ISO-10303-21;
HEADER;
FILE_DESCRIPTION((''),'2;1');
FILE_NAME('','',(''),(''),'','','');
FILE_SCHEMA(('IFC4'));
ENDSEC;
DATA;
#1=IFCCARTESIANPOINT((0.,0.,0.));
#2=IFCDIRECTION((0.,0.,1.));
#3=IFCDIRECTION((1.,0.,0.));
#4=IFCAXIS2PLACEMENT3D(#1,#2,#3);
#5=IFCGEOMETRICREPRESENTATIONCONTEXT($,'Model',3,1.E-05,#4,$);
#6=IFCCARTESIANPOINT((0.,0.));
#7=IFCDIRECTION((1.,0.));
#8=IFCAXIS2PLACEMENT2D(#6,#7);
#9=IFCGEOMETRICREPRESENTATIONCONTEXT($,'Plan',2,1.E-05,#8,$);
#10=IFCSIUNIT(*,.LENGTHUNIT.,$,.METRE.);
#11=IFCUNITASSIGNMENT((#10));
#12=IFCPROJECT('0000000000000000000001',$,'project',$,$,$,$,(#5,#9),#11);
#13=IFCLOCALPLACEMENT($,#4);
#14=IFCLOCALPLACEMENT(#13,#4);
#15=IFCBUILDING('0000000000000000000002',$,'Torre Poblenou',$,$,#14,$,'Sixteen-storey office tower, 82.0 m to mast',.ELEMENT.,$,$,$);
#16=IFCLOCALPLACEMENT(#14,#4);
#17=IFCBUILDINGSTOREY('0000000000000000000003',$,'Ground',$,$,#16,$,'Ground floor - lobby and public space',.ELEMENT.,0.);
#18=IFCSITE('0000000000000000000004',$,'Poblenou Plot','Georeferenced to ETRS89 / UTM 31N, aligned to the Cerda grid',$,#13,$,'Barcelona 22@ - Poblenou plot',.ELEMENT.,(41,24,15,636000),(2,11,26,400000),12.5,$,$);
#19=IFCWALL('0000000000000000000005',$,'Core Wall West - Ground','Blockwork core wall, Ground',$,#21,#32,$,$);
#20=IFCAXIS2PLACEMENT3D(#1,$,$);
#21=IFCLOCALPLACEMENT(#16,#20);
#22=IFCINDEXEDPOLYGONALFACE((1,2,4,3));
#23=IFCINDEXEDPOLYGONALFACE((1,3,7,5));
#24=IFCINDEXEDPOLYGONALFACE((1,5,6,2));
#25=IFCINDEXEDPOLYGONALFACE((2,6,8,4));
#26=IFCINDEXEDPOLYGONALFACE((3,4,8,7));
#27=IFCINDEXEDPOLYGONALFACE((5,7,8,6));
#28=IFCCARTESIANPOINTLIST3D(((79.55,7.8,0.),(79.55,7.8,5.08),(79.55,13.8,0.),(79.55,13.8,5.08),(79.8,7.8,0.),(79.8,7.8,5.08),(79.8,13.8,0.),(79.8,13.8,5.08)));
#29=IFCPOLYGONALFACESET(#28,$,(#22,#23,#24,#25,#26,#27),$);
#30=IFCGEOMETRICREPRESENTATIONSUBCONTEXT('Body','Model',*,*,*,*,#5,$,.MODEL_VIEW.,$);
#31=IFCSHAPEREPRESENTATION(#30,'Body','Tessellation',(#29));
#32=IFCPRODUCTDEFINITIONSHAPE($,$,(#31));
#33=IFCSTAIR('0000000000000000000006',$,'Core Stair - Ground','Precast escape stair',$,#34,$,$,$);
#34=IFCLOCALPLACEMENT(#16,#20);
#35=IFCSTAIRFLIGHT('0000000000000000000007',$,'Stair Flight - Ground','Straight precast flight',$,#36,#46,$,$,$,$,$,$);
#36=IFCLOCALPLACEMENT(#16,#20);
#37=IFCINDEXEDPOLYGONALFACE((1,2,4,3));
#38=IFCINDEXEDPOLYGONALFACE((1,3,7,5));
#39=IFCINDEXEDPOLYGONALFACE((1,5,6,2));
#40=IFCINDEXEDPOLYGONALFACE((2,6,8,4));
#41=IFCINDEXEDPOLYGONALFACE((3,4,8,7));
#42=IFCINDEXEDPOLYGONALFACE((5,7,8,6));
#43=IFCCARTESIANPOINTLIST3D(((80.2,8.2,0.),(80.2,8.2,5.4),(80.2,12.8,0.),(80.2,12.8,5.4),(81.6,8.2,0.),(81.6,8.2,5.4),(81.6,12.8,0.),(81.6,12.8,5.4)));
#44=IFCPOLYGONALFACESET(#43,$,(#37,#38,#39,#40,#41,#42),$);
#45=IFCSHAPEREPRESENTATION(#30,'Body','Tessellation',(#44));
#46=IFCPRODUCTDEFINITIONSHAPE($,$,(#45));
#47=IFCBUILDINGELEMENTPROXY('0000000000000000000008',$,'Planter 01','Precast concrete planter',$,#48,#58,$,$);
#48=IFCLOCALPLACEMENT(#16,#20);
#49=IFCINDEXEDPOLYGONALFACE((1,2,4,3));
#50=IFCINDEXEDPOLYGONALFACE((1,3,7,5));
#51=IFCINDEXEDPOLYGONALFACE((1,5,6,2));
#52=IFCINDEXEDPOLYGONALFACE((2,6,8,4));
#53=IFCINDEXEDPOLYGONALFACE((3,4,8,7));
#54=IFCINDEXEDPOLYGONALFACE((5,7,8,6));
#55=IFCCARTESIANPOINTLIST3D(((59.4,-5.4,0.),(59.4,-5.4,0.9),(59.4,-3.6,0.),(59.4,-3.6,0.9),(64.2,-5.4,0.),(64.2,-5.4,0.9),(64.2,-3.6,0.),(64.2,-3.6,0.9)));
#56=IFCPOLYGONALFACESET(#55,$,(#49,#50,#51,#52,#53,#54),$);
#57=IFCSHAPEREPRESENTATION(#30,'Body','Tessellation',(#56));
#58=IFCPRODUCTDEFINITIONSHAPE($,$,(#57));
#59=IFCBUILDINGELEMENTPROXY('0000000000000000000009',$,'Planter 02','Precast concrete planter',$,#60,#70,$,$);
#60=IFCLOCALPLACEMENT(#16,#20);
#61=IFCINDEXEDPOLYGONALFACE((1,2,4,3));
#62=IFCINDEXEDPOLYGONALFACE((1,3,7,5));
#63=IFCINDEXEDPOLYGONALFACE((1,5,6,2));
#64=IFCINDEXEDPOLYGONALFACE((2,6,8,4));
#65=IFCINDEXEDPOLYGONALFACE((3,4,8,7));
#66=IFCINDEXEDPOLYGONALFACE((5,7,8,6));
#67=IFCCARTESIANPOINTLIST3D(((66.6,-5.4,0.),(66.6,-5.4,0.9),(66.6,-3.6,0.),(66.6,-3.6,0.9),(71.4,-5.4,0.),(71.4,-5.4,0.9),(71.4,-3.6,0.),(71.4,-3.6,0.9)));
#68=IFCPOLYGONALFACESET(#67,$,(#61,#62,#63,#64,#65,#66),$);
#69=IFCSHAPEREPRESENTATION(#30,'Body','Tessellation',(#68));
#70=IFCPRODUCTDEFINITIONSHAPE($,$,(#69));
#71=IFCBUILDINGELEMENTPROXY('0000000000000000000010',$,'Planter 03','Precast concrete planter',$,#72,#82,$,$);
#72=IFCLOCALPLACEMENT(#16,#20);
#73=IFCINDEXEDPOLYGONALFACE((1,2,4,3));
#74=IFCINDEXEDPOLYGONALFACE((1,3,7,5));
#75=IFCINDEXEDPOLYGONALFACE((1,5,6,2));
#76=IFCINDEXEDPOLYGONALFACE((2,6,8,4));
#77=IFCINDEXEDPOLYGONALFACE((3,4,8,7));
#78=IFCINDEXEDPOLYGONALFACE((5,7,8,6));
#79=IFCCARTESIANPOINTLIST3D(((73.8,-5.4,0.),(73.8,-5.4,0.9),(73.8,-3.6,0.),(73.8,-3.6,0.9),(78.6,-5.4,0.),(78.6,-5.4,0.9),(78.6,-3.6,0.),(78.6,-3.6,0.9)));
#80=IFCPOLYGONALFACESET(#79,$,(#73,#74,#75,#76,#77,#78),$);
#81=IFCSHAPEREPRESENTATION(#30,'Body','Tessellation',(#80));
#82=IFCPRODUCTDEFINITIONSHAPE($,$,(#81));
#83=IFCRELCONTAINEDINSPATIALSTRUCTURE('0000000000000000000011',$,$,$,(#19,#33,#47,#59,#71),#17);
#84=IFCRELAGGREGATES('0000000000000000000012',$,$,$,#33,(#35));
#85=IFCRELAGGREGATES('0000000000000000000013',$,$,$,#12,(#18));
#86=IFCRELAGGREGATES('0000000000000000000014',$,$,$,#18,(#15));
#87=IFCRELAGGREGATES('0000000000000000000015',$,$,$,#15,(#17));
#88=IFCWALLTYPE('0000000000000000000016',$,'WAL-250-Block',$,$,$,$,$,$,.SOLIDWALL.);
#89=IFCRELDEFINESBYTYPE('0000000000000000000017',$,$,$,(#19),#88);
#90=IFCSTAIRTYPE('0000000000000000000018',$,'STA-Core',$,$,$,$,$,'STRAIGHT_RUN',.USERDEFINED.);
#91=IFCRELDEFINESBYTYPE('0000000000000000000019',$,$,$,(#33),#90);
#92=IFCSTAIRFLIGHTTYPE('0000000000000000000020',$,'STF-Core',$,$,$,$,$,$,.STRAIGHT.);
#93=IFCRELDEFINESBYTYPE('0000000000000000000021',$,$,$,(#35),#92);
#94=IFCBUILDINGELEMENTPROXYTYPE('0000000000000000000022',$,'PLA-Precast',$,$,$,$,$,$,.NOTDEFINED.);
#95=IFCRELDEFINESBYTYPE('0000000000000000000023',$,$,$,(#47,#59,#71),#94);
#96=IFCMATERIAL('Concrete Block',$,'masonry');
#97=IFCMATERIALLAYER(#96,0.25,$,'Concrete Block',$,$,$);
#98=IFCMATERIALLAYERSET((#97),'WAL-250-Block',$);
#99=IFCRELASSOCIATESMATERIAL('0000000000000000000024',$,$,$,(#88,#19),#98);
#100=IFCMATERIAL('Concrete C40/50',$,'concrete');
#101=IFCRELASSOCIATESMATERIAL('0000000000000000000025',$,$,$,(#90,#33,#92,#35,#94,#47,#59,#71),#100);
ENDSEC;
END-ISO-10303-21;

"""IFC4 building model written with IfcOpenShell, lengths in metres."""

from ifc_helpers import new_model, si_unit, frame, origin_with_axes, origin_2d_with_axis, place, context, subcontext, project, spatial, line, indexed_curve, outline, extrude, material, layer, layer_set, layer_usage, type_object, element, aggregate, save


model = new_model("IFC4")

# Units and contexts
model_context = context("Model", 3, precision=1e-05, world=origin_with_axes())
plan_context = context("Plan", 2, precision=1e-05, world=origin_2d_with_axis())
body_context = subcontext(model_context, "Body", "Model", "MODEL_VIEW")
ifc_project = project(units=[si_unit("LENGTHUNIT", "METRE")], contexts=[model_context, plan_context])

# Site, building, storey
site_placement = place(None, origin_with_axes())
site = spatial("IfcSite", under=ifc_project, at=site_placement, Name="Poblenou Plot", Description="Georeferenced to ETRS89 / UTM 31N, aligned to the Cerda grid", LongName="Barcelona 22@ - Poblenou plot", CompositionType="ELEMENT", RefLatitude=(41, 24, 15, 636000), RefLongitude=(2, 11, 26, 400000), RefElevation=12.5)
building_placement = place(site_placement, origin_with_axes())
building = spatial("IfcBuilding", under=site, at=building_placement, Name="Torre Poblenou", LongName="Sixteen-storey office tower, 82.0 m to mast", CompositionType="ELEMENT")
storey_placement = place(building_placement, origin_with_axes())
storey = spatial("IfcBuildingStorey", under=building, at=storey_placement, Name="Ground", LongName="Ground floor - lobby and public space", CompositionType="ELEMENT", Elevation=0.0)

# Shared definitions
ifc_material_1 = material(Name="Concrete C40/50", Category="concrete")

# Wall
ifc_material_2 = material(Name="Concrete Block", Category="masonry")
ifc_layer_1 = layer(ifc_material_2, 0.25, Name="Concrete Block")
ifc_layer_set_1 = layer_set([ifc_layer_1], Name="WAL-250-Block")
ifc_layer_usage_1 = layer_usage(ifc_layer_set_1, "AXIS2", "POSITIVE", 0.0)
wall_type = type_object("IfcWallType", Name="WAL-250-Block", PredefinedType="SOLIDWALL", material=ifc_layer_set_1)
wall_placement = place(storey_placement, frame((79.8, 7.8, 0.0), z_axis=(0.0, 0.0, 1.0), x_axis=(0.0, 1.0, 0.0)))
element("IfcWall", 1, at=wall_placement, inside=storey, type_object=wall_type, material=ifc_layer_usage_1, Name="Core Wall West - Ground", Description="Blockwork core wall, Ground", context=body_context, shape_type="SweptSolid", body=[
    extrude(outline(indexed_curve([(0.0, 0.0), (6.0, 0.0), (6.0, 0.25), (0.0, 0.25)], segments=[line(1, 2, 3, 4, 1)])), origin_with_axes(), (0.0, 0.0, 1.0), 5.08),
])

# Stair, stair flight
stair_type = type_object("IfcStairType", Name="STA-Core", ElementType="STRAIGHT_RUN", PredefinedType="USERDEFINED", material=ifc_material_1)
stair_placement = place(storey_placement, frame((80.2, 8.2, 0.0), z_axis=(0.0, 0.0, 1.0), x_axis=(1.0, 0.0, 0.0)))
stair = element("IfcStair", 2, at=stair_placement, inside=storey, type_object=stair_type, material=ifc_material_1, Name="Core Stair - Ground", Description="Precast escape stair")
stair_flight_type = type_object("IfcStairFlightType", Name="STF-Core", PredefinedType="STRAIGHT", material=ifc_material_1)
stair_flight_placement = place(stair_placement, origin_with_axes())
stair_flight = element("IfcStairFlight", 3, at=stair_flight_placement, type_object=stair_flight_type, material=ifc_material_1, Name="Stair Flight - Ground", Description="Straight precast flight", context=body_context, shape_type="SweptSolid", body=[
    extrude(outline(indexed_curve([(0.0, 0.0), (1.4, 0.0), (1.4, 4.6), (0.0, 4.6)], segments=[line(1, 2, 3, 4, 1)])), origin_with_axes(), (0.0, 0.0, 1.0), 5.4),
])
aggregate(stair, [stair_flight])

# Building element proxies
building_element_proxy_type = type_object("IfcBuildingElementProxyType", Name="PLA-Precast", PredefinedType="NOTDEFINED", material=ifc_material_1)
for number, where, z_axis, x_axis, name in (
    (4, (59.4, -5.4, 0.0), (0.0, 0.0, 1.0), (1.0, 0.0, 0.0), "Planter 01"),
    (5, (66.6, -5.4, 0.0), (0.0, 0.0, 1.0), (1.0, 0.0, 0.0), "Planter 02"),
    (6, (73.8, -5.4, 0.0), (0.0, 0.0, 1.0), (1.0, 0.0, 0.0), "Planter 03"),
):
    element("IfcBuildingElementProxy", number, at=place(storey_placement, frame(where, z_axis=z_axis, x_axis=x_axis)), inside=storey, type_object=building_element_proxy_type, material=ifc_material_1, Name=name, Description="Precast concrete planter", context=body_context, shape_type="SweptSolid", body=[
        extrude(outline(indexed_curve([(0.0, 0.0), (4.8, 0.0), (4.8, 1.8), (0.0, 1.8)], segments=[line(1, 2, 3, 4, 1)])), origin_with_axes(), (0.0, 0.0, 1.0), 0.9),
    ])

save(model, "model.ifc")
